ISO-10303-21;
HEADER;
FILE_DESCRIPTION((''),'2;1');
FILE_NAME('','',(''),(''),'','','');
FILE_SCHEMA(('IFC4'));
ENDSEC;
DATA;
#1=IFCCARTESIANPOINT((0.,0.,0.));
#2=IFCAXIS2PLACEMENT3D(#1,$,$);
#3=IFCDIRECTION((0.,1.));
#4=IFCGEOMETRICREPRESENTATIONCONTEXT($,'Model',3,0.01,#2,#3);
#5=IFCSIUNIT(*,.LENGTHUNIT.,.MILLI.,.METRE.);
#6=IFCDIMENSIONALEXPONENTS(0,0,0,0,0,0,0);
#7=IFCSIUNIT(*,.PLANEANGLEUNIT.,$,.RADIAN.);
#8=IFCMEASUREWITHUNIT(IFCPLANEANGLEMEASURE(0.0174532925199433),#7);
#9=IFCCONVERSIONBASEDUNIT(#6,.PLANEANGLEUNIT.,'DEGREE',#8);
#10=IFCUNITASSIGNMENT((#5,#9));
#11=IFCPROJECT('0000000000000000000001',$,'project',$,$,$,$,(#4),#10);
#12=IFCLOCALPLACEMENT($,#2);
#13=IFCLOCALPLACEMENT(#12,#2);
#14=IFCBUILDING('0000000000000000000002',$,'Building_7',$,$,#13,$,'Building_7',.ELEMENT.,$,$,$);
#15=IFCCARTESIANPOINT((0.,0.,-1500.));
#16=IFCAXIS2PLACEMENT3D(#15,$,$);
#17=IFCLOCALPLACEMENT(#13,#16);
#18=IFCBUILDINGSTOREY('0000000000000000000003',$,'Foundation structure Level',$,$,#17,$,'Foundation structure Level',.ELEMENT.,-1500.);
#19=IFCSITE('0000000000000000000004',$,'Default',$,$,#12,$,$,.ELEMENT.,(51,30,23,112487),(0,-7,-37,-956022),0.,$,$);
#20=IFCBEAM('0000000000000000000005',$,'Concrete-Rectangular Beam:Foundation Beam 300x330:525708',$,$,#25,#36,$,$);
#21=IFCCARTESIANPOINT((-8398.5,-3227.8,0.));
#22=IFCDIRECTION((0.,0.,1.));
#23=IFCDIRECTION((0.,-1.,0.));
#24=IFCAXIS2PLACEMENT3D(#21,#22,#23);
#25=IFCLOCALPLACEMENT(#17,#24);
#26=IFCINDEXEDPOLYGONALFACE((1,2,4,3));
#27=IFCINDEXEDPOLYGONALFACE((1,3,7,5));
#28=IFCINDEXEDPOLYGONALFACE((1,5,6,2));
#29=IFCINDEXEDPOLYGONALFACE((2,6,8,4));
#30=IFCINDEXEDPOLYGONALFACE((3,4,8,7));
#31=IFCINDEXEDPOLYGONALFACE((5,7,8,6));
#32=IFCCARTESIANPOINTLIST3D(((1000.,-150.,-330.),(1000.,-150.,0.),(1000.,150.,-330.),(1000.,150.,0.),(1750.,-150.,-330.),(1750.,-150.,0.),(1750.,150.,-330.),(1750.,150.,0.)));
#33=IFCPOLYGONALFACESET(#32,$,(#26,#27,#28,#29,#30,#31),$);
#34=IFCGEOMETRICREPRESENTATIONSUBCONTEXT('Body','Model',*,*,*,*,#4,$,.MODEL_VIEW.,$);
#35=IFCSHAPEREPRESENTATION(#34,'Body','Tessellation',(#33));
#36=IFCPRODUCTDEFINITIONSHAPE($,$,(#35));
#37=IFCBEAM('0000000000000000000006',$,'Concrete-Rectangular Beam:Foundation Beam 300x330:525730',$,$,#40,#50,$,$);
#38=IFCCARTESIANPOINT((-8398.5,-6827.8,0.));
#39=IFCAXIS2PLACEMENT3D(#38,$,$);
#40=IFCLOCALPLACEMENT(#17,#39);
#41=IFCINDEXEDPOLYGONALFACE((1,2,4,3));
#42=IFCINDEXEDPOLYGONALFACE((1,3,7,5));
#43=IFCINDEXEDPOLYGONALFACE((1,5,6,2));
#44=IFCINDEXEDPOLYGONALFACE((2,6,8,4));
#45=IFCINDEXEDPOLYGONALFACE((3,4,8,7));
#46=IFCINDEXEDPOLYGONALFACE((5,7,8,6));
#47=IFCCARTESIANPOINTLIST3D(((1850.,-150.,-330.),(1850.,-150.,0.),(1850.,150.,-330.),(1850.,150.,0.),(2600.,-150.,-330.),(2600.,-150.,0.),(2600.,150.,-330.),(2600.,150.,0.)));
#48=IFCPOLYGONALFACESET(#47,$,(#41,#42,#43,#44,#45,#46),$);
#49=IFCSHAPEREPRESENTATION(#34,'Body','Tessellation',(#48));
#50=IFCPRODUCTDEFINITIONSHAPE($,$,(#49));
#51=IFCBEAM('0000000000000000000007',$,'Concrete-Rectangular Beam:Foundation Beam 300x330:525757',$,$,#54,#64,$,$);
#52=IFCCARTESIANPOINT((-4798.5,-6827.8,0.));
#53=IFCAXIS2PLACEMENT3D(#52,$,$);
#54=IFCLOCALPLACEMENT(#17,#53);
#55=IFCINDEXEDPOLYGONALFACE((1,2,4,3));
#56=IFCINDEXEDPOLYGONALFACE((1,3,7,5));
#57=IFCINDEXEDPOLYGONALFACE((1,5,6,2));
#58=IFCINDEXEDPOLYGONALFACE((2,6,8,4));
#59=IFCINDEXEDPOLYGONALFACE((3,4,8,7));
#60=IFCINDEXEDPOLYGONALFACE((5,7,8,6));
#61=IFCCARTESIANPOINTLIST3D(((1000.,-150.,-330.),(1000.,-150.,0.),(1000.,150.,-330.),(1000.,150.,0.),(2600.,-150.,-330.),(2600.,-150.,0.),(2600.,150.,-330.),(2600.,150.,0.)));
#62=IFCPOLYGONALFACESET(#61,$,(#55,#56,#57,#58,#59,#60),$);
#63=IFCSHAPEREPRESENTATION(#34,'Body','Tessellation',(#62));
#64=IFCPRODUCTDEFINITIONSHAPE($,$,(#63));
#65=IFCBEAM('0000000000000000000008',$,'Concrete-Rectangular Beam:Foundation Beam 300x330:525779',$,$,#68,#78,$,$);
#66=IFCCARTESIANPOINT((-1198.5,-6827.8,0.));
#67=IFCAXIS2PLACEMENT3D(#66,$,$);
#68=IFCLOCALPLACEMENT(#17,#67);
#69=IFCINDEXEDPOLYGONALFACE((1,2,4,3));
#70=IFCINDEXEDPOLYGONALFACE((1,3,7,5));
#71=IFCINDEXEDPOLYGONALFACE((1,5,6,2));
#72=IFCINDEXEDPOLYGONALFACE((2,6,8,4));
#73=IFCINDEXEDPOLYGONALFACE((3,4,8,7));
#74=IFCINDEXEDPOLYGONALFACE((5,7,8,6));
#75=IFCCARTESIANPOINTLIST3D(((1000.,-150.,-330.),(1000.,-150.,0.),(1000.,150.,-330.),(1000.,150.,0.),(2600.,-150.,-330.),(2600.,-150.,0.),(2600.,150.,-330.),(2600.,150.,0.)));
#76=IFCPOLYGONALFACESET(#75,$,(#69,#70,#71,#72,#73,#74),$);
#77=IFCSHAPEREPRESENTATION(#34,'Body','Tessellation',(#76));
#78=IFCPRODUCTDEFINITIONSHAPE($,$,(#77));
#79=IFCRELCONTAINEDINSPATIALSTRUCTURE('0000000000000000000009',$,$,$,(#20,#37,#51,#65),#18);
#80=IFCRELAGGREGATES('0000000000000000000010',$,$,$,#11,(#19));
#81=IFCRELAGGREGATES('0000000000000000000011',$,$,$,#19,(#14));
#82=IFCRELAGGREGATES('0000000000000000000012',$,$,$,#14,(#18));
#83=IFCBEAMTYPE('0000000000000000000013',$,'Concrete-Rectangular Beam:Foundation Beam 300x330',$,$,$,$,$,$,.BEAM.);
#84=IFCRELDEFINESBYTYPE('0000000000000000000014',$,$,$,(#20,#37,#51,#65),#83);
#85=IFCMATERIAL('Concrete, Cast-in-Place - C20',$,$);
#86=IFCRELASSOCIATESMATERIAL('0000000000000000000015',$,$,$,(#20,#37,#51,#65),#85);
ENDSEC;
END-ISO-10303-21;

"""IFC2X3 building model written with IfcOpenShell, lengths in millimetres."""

from ifc_helpers import new_model, entity, si_unit, converted_unit, direction, frame, frame_2d, origin, place, context, subcontext, project, spatial, rectangle, extrude, material, type_object, element, save


model = new_model("IFC2X3")

# Units and contexts
model_context = context("Model", 3, precision=0.01, world=origin(), true_north=direction((0.0, 1.0)))
body_context = subcontext(model_context, "Body", "Model", "MODEL_VIEW")
ifc_project = project(units=[si_unit("LENGTHUNIT", "METRE", prefix="MILLI"), converted_unit("PLANEANGLEUNIT", "DEGREE", entity("IfcPlaneAngleMeasure", 0.0174532925199433), si_unit("PLANEANGLEUNIT", "RADIAN"), dimensions=[0, 0, 0, 0, 0, 0, 0])], contexts=[model_context])

# Site, building, storey
site_placement = place(None, origin())
site = spatial("IfcSite", under=ifc_project, at=site_placement, Name="Default", CompositionType="ELEMENT", RefLatitude=(51, 30, 23, 112487), RefLongitude=(0, -7, -37, -956022), RefElevation=0.0)
building_placement = place(site_placement, origin())
building = spatial("IfcBuilding", under=site, at=building_placement, Name="Building_7", LongName="Building_7", CompositionType="ELEMENT")
storey_placement = place(building_placement, frame((0.0, 0.0, -1500.0)))
storey = spatial("IfcBuildingStorey", under=building, at=storey_placement, Name="Foundation structure Level", LongName="Foundation structure Level", CompositionType="ELEMENT", Elevation=-1500.0)

# Beams
ifc_material_1 = material(Name="Concrete, Cast-in-Place - C20")
beam_type = type_object("IfcBeamType", Name="Concrete-Rectangular Beam:Foundation Beam 300x330", PredefinedType="BEAM")
beam_1_placement = place(storey_placement, frame((-8398.5, -3227.8, 0.0), z_axis=(0.0, 0.0, 1.0), x_axis=(0.0, -1.0, 0.0)))
element("IfcBeam", 1, at=beam_1_placement, inside=storey, type_object=beam_type, material=ifc_material_1, Name="Concrete-Rectangular Beam:Foundation Beam 300x330:525708", context=body_context, shape_type="SweptSolid", body=[
    extrude(rectangle(XDim=330.0, YDim=300.0, at=frame_2d((0.0, 0.0), x_axis=(1.0, 0.0))), frame((1000.0, 0.0, -165.0), z_axis=(1.0, 0.0, 0.0), x_axis=(0.0, 0.0, -1.0)), (0.0, 0.0, 1.0), 750.0),
])
beam_2_placement = place(storey_placement, frame((-8398.5, -6827.8, 0.0)))
element("IfcBeam", 2, at=beam_2_placement, inside=storey, type_object=beam_type, material=ifc_material_1, Name="Concrete-Rectangular Beam:Foundation Beam 300x330:525730", context=body_context, shape_type="SweptSolid", body=[
    extrude(rectangle(XDim=330.0, YDim=300.0, at=frame_2d((0.0, 0.0), x_axis=(1.0, 0.0))), frame((1850.0, 0.0, -165.0), z_axis=(1.0, 0.0, 0.0), x_axis=(0.0, 0.0, -1.0)), (0.0, 0.0, 1.0), 750.0),
])
beam_3_placement = place(storey_placement, frame((-4798.5, -6827.8, 0.0)))
element("IfcBeam", 3, at=beam_3_placement, inside=storey, type_object=beam_type, material=ifc_material_1, Name="Concrete-Rectangular Beam:Foundation Beam 300x330:525757", context=body_context, shape_type="SweptSolid", body=[
    extrude(rectangle(XDim=330.0, YDim=300.0, at=frame_2d((0.0, 0.0), x_axis=(1.0, 0.0))), frame((1000.0, 0.0, -165.0), z_axis=(1.0, 0.0, 0.0), x_axis=(0.0, 0.0, -1.0)), (0.0, 0.0, 1.0), 1600.0),
])
beam_4_placement = place(storey_placement, frame((-1198.5, -6827.8, 0.0)))
element("IfcBeam", 4, at=beam_4_placement, inside=storey, type_object=beam_type, material=ifc_material_1, Name="Concrete-Rectangular Beam:Foundation Beam 300x330:525779", context=body_context, shape_type="SweptSolid", body=[
    extrude(rectangle(XDim=330.0, YDim=300.0, at=frame_2d((0.0, 0.0), x_axis=(1.0, 0.0))), frame((1000.0, 0.0, -165.0), z_axis=(1.0, 0.0, 0.0), x_axis=(0.0, 0.0, -1.0)), (0.0, 0.0, 1.0), 1600.0),
])

save(model, "model.ifc")
